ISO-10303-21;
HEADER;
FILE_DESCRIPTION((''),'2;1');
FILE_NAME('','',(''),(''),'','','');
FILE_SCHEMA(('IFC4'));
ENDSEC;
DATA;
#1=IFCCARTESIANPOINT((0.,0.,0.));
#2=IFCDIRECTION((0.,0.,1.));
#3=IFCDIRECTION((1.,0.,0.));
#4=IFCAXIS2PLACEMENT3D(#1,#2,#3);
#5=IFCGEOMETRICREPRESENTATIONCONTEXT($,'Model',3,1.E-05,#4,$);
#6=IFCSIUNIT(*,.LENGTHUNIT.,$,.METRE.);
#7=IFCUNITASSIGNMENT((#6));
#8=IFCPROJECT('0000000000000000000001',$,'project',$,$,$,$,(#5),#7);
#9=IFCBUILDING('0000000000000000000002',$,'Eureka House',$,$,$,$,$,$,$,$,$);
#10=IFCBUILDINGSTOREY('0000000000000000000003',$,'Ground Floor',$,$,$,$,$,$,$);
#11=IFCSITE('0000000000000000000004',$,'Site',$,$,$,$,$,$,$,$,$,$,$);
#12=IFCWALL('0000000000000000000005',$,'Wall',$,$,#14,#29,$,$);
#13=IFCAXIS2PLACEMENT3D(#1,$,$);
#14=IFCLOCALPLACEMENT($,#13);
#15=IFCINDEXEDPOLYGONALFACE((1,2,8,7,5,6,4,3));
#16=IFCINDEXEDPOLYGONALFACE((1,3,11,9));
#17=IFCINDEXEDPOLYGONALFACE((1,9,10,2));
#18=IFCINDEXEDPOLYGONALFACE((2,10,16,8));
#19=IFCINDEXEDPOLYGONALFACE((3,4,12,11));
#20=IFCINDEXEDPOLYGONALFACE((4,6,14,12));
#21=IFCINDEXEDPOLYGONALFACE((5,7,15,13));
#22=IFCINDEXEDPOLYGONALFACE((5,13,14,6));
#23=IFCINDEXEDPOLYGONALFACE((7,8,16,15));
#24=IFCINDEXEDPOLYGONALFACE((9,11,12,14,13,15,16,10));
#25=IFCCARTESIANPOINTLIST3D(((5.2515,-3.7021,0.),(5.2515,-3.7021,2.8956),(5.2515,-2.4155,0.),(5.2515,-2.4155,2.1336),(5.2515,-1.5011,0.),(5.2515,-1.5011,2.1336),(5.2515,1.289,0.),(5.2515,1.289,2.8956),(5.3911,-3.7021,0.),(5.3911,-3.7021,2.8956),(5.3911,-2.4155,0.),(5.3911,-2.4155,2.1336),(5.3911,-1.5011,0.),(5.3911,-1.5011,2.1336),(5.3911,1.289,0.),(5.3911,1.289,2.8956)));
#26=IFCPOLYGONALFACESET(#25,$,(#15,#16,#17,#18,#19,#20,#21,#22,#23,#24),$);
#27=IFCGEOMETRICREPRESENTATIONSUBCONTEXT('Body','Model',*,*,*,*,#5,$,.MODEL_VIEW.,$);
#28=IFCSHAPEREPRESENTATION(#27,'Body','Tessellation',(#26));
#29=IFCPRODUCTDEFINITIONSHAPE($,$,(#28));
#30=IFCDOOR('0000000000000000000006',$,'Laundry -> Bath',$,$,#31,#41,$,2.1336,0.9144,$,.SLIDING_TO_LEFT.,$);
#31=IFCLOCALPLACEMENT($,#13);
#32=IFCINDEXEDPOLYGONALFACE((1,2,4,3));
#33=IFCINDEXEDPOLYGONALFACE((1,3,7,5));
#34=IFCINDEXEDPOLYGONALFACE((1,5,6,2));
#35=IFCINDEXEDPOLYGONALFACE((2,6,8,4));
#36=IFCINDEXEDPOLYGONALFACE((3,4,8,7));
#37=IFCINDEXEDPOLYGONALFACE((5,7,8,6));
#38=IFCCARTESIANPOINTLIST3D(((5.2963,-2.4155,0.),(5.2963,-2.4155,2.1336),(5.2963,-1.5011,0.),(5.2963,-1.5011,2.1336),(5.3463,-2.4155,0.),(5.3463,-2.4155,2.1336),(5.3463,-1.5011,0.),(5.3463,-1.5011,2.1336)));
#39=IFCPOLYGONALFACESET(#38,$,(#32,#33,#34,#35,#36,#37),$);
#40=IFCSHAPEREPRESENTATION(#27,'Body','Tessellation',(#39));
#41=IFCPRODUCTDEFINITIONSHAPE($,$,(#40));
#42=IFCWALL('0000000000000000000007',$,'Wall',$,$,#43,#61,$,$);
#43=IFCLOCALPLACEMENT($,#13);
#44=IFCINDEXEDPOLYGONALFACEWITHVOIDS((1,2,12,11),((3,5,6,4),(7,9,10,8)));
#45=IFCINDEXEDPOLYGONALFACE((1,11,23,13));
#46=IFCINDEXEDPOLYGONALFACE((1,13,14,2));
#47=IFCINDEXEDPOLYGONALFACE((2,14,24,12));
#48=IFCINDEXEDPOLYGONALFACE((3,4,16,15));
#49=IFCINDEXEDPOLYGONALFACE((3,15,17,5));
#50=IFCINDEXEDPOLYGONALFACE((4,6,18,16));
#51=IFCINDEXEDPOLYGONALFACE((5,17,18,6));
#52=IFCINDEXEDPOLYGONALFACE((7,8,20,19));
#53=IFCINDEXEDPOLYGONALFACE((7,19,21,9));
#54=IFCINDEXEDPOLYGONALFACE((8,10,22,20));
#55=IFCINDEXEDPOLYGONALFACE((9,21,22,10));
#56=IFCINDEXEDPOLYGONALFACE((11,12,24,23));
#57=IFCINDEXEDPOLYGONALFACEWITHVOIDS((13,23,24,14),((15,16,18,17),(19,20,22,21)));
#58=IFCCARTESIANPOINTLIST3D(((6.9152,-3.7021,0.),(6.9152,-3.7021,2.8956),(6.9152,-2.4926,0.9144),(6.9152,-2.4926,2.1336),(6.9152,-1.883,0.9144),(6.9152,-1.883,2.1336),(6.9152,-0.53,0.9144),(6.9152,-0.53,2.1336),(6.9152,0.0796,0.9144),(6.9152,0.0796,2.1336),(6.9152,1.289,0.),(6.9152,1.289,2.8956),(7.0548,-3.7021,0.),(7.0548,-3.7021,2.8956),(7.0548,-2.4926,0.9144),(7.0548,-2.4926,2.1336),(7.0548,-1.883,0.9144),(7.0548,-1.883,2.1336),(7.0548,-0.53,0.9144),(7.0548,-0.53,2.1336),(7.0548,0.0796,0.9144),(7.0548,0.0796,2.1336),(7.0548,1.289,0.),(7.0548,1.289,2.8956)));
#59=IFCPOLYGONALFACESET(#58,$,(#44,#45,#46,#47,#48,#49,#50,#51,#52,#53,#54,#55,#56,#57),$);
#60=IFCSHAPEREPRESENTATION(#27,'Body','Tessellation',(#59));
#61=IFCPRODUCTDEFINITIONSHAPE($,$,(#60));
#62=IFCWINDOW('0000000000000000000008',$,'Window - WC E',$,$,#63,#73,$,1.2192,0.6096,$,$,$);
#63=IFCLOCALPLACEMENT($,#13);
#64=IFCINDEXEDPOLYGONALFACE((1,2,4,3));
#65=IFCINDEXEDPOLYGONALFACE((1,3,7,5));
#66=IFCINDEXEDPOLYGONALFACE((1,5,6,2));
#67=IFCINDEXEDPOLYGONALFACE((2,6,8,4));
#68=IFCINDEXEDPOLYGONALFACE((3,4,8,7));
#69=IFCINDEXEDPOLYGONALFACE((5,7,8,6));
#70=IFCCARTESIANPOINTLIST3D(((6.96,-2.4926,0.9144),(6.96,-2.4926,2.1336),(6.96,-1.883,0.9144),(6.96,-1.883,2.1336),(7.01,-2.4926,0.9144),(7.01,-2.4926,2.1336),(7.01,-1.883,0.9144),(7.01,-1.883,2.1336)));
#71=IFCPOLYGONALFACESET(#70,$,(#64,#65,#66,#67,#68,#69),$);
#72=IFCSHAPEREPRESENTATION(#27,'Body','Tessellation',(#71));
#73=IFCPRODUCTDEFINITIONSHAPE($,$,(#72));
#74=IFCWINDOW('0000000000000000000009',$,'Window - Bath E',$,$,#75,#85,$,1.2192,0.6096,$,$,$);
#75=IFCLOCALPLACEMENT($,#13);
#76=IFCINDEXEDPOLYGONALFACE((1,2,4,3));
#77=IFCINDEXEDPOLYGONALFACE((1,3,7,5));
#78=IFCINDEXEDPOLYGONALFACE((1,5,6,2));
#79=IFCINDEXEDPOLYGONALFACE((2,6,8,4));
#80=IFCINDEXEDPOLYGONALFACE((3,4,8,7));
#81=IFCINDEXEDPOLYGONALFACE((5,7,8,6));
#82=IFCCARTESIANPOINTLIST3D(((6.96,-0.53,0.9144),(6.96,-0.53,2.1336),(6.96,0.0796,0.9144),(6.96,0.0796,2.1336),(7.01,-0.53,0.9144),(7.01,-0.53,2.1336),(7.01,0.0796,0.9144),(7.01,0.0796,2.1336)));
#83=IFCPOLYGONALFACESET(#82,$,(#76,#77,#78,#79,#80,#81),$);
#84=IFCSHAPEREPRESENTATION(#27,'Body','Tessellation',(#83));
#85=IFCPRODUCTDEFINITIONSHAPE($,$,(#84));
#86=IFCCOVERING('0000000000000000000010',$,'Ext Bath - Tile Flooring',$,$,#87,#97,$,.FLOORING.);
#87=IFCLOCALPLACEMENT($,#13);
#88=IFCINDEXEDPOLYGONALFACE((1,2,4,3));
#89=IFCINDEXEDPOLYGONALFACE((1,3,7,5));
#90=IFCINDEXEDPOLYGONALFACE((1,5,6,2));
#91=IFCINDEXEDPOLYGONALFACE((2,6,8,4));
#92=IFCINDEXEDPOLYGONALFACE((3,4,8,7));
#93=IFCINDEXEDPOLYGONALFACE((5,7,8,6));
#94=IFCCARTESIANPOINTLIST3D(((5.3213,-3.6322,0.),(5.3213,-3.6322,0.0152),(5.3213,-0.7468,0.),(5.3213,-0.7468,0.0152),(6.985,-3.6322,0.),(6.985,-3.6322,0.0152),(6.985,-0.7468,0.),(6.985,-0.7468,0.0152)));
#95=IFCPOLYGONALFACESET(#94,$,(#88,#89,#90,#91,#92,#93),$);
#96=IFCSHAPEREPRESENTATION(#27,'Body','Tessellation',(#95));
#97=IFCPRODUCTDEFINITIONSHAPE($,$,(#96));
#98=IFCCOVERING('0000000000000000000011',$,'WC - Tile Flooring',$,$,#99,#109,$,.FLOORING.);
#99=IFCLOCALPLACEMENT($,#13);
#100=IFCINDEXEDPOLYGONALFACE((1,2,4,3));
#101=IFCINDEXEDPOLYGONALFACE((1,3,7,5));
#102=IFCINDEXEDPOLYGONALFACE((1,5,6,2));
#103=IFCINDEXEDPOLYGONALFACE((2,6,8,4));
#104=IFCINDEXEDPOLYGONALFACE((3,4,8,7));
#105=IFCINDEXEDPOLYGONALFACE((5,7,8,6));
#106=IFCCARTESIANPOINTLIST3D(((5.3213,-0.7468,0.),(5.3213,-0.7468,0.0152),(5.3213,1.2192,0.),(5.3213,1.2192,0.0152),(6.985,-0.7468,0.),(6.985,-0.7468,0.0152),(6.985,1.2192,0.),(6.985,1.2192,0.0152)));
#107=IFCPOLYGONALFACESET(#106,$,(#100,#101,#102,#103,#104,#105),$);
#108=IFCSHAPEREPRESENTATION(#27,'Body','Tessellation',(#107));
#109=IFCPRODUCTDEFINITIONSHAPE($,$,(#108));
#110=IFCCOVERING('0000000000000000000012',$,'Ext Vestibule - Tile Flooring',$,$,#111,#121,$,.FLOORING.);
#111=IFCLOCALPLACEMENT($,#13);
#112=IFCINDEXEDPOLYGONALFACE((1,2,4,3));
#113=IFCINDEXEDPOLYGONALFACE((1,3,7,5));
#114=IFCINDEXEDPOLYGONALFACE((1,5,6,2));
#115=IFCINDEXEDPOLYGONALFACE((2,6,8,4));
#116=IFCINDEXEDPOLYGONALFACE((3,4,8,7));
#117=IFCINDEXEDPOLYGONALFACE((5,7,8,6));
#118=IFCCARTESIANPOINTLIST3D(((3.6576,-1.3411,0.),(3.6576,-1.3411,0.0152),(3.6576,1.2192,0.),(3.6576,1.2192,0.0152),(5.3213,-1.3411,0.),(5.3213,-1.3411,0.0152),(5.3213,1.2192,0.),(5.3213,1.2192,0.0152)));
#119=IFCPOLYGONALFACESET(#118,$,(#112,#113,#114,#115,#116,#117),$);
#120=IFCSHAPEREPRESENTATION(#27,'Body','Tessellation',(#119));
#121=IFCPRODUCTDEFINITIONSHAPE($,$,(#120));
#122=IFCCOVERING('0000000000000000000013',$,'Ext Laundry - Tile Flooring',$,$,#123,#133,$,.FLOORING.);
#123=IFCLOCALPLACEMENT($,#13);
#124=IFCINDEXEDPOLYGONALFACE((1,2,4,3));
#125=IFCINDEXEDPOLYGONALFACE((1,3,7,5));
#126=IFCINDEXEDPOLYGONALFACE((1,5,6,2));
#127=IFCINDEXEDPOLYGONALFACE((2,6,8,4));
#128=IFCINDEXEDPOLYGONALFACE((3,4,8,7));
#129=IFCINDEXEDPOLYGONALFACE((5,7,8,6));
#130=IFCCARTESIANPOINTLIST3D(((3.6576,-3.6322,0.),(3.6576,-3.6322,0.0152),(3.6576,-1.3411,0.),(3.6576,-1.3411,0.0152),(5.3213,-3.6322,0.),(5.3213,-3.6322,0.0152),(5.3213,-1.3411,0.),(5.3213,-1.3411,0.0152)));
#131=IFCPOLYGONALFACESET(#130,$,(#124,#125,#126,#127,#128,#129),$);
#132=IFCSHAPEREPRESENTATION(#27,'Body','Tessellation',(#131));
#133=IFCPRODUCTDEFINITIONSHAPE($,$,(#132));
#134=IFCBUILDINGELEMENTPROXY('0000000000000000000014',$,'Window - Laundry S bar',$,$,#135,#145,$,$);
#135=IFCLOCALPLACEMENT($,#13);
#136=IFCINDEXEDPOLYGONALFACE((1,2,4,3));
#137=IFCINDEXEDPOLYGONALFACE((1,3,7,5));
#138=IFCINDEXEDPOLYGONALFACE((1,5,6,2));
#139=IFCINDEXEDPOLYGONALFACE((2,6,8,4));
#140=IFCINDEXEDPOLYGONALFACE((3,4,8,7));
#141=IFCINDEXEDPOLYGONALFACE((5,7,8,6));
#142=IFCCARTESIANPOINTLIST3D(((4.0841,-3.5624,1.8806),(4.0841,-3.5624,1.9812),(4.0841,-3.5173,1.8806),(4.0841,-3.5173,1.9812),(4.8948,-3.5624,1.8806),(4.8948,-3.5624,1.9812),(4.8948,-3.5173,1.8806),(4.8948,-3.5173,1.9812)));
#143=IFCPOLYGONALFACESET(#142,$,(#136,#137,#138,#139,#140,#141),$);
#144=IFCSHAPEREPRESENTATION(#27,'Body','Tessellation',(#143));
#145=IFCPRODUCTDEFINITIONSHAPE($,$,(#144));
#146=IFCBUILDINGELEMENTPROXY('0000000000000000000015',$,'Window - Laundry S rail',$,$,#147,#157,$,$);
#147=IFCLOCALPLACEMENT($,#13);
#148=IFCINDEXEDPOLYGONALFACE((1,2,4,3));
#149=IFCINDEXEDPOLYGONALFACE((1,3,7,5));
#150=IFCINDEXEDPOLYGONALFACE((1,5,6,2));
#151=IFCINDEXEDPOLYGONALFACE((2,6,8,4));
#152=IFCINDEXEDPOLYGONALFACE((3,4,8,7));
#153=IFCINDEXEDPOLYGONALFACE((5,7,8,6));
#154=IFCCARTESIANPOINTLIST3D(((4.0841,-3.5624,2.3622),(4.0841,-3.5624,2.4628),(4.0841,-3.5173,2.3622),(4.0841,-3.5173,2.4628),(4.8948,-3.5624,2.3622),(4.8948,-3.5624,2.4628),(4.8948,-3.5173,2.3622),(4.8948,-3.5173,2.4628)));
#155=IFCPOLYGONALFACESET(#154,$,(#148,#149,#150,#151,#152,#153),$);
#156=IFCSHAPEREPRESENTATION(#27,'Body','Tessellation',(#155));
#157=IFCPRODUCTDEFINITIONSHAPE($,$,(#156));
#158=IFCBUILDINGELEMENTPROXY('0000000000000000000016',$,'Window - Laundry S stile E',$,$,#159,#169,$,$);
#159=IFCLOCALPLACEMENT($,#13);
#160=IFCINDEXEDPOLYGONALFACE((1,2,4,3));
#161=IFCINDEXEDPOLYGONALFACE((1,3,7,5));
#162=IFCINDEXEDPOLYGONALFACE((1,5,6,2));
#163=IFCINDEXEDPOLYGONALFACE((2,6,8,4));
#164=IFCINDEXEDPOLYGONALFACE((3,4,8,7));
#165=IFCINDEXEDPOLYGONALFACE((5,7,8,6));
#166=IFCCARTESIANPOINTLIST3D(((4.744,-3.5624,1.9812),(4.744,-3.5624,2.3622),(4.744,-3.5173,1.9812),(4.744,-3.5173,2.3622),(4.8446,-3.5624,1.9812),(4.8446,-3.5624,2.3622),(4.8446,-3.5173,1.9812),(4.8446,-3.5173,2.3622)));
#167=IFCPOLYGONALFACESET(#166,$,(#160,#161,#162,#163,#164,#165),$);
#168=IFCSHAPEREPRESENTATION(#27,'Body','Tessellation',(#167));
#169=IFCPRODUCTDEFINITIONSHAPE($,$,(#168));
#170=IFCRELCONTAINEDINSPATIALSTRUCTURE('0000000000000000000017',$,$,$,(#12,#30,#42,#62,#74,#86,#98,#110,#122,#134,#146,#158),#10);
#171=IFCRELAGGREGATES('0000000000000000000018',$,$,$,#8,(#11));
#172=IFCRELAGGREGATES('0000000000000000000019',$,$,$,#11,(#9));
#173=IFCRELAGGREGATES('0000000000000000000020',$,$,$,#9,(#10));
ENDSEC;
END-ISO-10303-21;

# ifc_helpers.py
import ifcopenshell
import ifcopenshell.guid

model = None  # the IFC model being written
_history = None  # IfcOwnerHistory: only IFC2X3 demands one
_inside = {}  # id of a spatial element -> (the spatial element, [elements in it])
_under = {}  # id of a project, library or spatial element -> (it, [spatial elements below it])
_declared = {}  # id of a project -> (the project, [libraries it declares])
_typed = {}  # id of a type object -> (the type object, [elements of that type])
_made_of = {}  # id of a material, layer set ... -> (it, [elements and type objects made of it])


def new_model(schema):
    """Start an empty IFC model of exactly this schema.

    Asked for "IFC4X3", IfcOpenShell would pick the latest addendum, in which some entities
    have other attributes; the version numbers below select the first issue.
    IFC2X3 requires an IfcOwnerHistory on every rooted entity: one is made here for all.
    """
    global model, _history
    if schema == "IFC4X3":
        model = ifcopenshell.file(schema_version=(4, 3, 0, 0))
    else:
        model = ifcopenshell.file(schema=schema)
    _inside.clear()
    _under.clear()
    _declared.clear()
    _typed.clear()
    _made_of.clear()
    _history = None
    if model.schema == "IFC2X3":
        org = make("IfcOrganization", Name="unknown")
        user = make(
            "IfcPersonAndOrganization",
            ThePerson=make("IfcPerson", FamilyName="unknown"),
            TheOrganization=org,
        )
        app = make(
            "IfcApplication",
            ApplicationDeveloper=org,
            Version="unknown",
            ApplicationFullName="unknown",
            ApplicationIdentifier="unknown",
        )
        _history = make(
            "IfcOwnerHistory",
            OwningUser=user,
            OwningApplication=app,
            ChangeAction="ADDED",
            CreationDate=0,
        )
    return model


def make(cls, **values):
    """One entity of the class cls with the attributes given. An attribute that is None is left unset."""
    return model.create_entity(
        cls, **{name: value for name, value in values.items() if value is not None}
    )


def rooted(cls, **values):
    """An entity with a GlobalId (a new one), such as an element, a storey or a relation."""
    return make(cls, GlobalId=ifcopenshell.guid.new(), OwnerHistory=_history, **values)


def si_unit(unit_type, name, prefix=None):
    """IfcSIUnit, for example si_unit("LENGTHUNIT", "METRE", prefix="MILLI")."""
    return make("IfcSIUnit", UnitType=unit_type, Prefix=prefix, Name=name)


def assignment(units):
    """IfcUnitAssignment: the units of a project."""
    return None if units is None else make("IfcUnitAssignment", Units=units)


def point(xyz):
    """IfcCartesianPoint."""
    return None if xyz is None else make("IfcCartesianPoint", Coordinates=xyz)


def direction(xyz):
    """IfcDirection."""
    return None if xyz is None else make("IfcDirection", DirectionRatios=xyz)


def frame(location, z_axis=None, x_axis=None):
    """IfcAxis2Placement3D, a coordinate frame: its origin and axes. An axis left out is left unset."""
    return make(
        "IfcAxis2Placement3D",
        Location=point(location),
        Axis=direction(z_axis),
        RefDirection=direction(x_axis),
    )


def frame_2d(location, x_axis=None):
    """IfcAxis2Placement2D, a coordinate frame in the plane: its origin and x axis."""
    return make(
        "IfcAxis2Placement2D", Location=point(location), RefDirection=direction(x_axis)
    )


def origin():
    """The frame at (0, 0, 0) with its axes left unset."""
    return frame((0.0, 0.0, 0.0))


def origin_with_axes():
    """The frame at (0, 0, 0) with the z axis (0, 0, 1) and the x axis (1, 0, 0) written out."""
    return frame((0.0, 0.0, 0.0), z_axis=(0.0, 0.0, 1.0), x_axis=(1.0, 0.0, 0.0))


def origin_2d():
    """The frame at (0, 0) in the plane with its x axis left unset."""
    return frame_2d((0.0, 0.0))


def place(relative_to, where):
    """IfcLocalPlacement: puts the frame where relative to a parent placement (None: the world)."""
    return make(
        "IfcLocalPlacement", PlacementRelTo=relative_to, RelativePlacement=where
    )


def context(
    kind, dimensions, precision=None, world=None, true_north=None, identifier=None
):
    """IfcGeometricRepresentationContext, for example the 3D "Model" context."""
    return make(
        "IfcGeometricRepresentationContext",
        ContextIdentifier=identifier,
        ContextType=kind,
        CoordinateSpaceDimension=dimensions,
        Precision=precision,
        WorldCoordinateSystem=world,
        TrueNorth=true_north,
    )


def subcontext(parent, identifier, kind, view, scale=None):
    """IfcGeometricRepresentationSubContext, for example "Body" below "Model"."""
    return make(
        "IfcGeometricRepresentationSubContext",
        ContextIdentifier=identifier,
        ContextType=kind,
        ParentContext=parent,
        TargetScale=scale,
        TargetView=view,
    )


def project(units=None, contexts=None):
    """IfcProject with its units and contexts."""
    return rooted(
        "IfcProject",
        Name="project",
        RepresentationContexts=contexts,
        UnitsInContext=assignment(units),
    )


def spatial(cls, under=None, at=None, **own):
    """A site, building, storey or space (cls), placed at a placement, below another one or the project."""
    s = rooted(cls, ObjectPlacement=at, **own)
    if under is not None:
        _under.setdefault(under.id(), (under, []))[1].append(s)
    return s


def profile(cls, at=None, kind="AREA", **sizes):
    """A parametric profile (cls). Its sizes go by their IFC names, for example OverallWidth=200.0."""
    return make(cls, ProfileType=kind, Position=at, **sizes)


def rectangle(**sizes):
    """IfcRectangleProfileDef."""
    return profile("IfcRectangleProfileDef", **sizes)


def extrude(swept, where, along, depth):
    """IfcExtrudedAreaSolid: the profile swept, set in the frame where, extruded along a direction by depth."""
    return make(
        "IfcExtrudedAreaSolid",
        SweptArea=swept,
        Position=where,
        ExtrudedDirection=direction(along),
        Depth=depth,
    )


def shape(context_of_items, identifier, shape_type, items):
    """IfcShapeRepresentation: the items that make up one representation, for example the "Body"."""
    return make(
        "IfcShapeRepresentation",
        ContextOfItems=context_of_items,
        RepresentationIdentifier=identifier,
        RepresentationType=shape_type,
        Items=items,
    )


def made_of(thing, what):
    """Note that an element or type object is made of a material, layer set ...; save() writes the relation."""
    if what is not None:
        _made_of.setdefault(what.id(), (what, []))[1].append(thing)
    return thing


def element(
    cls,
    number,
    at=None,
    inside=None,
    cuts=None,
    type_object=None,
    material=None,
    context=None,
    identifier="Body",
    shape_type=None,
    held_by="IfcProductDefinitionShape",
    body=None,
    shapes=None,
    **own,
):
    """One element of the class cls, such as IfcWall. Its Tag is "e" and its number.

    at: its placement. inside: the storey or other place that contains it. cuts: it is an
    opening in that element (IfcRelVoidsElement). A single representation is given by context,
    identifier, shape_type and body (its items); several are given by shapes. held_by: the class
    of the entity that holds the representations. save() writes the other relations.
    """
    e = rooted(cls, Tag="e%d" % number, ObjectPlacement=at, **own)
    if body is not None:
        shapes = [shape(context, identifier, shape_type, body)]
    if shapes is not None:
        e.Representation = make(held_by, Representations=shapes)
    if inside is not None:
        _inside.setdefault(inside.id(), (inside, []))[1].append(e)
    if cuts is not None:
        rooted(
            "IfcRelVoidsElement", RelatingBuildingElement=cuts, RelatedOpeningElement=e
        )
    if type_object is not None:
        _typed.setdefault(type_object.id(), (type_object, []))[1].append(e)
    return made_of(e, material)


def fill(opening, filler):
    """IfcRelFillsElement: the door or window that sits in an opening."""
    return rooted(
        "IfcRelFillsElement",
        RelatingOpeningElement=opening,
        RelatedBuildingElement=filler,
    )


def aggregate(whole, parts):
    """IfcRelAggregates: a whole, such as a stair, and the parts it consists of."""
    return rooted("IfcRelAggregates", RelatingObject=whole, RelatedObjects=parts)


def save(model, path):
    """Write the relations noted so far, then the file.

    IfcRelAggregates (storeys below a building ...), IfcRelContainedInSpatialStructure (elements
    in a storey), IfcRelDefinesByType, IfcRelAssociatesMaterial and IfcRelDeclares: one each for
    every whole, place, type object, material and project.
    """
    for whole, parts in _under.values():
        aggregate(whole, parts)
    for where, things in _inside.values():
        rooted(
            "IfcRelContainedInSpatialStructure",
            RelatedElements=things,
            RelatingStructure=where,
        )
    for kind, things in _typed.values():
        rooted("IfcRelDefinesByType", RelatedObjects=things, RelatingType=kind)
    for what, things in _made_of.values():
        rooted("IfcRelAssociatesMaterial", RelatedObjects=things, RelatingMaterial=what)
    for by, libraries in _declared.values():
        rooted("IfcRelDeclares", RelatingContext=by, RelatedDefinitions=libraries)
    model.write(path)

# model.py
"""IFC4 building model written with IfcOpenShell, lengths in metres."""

from ifc_helpers import new_model, si_unit, frame, origin, origin_with_axes, origin_2d, place, context, subcontext, project, spatial, rectangle, extrude, element, fill, save


model = new_model("IFC4")

# Units and contexts
model_context = context("Model", 3, precision=1e-05, world=origin_with_axes())
body_context = subcontext(model_context, "Body", "Model", "MODEL_VIEW")
ifc_project = project(units=[si_unit("LENGTHUNIT", "METRE")], contexts=[model_context])

# Site, building, storey
site = spatial("IfcSite", under=ifc_project, Name="Site")
building = spatial("IfcBuilding", under=site, Name="Eureka House")
storey = spatial("IfcBuildingStorey", under=building, Name="Ground Floor")

# Wall, opening, door
wall_1_placement = place(None, frame((5.3213, -1.2065, 0.0), z_axis=(0.0, 0.0, 1.0), x_axis=(1.0, 0.0, 0.0)))
wall_1 = element("IfcWall", 1, at=wall_1_placement, inside=storey, Name="Wall", context=body_context, shape_type="SweptSolid", body=[
    extrude(rectangle(XDim=0.1397, YDim=4.9911, at=origin_2d()), origin(), (0.0, 0.0, 1.0), 2.8956),
])
opening_1_placement = place(wall_1_placement, frame((0.0, -0.7518, 0.0), z_axis=(0.0, 0.0, 1.0), x_axis=(1.0, 0.0, 0.0)))
opening_1 = element("IfcOpeningElement", 2, at=opening_1_placement, cuts=wall_1, context=body_context, shape_type="SweptSolid", body=[
    extrude(rectangle(XDim=0.2397, YDim=0.9144, at=origin_2d()), origin(), (0.0, 0.0, 1.0), 2.1336),
])
door_1_placement = place(opening_1_placement, origin_with_axes())
door_1 = element("IfcDoor", 3, at=door_1_placement, inside=storey, Name="Laundry -> Bath", OperationType="SLIDING_TO_LEFT", OverallHeight=2.1336, OverallWidth=0.9144, context=body_context, shape_type="SweptSolid", body=[
    extrude(rectangle(XDim=0.05, YDim=0.9144, at=origin_2d()), origin(), (0.0, 0.0, 1.0), 2.1336),
])
fill(opening_1, door_1)

# Wall, openings, windows
wall_2_placement = place(None, frame((6.985, -1.2065, 0.0), z_axis=(0.0, 0.0, 1.0), x_axis=(1.0, 0.0, 0.0)))
wall_2 = element("IfcWall", 4, at=wall_2_placement, inside=storey, Name="Wall", context=body_context, shape_type="SweptSolid", body=[
    extrude(rectangle(XDim=0.1397, YDim=4.9911, at=origin_2d()), origin(), (0.0, 0.0, 1.0), 2.8956),
])
opening_2_placement = place(wall_2_placement, frame((0.0, -0.9813, 0.9144), z_axis=(0.0, 0.0, 1.0), x_axis=(1.0, 0.0, 0.0)))
opening_2 = element("IfcOpeningElement", 5, at=opening_2_placement, cuts=wall_2, context=body_context, shape_type="SweptSolid", body=[
    extrude(rectangle(XDim=0.2397, YDim=0.6096, at=origin_2d()), origin(), (0.0, 0.0, 1.0), 1.2192),
])
opening_3_placement = place(wall_2_placement, frame((0.0, 0.9813, 0.9144), z_axis=(0.0, 0.0, 1.0), x_axis=(1.0, 0.0, 0.0)))
opening_3 = element("IfcOpeningElement", 6, at=opening_3_placement, cuts=wall_2, context=body_context, shape_type="SweptSolid", body=[
    extrude(rectangle(XDim=0.2397, YDim=0.6096, at=origin_2d()), origin(), (0.0, 0.0, 1.0), 1.2192),
])
window_1_placement = place(opening_2_placement, origin_with_axes())
window_1 = element("IfcWindow", 7, at=window_1_placement, inside=storey, Name="Window - WC E", OverallHeight=1.2192, OverallWidth=0.6096, context=body_context, shape_type="SweptSolid", body=[
    extrude(rectangle(XDim=0.05, YDim=0.6096, at=origin_2d()), origin(), (0.0, 0.0, 1.0), 1.2192),
])
fill(opening_2, window_1)
window_2_placement = place(opening_3_placement, frame((0.0, 0.0, 0.0), z_axis=(0.0, 0.0, 1.0), x_axis=(1.0, 0.0, 0.0)))
window_2 = element("IfcWindow", 8, at=window_2_placement, inside=storey, Name="Window - Bath E", OverallHeight=1.2192, OverallWidth=0.6096, context=body_context, shape_type="SweptSolid", body=[
    extrude(rectangle(XDim=0.05, YDim=0.6096, at=origin_2d()), origin(), (0.0, 0.0, 1.0), 1.2192),
])
fill(opening_3, window_2)

# Coverings
covering_1_placement = place(None, frame((6.1532, -2.1895, 0.0), z_axis=(0.0, 0.0, 1.0), x_axis=(1.0, 0.0, 0.0)))
element("IfcCovering", 9, at=covering_1_placement, inside=storey, Name="Ext Bath - Tile Flooring", PredefinedType="FLOORING", context=body_context, shape_type="SweptSolid", body=[
    extrude(rectangle(XDim=1.6637, YDim=2.8855, at=origin_2d()), origin(), (0.0, 0.0, 1.0), 0.0152),
])
covering_2_placement = place(None, frame((6.1532, 0.2362, 0.0), z_axis=(0.0, 0.0, 1.0), x_axis=(1.0, 0.0, 0.0)))
element("IfcCovering", 10, at=covering_2_placement, inside=storey, Name="WC - Tile Flooring", PredefinedType="FLOORING", context=body_context, shape_type="SweptSolid", body=[
    extrude(rectangle(XDim=1.6637, YDim=1.966, at=origin_2d()), origin(), (0.0, 0.0, 1.0), 0.0152),
])
covering_3_placement = place(None, frame((4.4894, -0.061, 0.0), z_axis=(0.0, 0.0, 1.0), x_axis=(1.0, 0.0, 0.0)))
element("IfcCovering", 11, at=covering_3_placement, inside=storey, Name="Ext Vestibule - Tile Flooring", PredefinedType="FLOORING", context=body_context, shape_type="SweptSolid", body=[
    extrude(rectangle(XDim=1.6637, YDim=2.5603, at=origin_2d()), origin(), (0.0, 0.0, 1.0), 0.0152),
])
covering_4_placement = place(None, frame((4.4894, -2.4867, 0.0), z_axis=(0.0, 0.0, 1.0), x_axis=(1.0, 0.0, 0.0)))
element("IfcCovering", 12, at=covering_4_placement, inside=storey, Name="Ext Laundry - Tile Flooring", PredefinedType="FLOORING", context=body_context, shape_type="SweptSolid", body=[
    extrude(rectangle(XDim=1.6637, YDim=2.2911, at=origin_2d()), origin(), (0.0, 0.0, 1.0), 0.0152),
])

# Building element proxies
for number, where, z_axis, x_axis, name in (
    (13, (4.4895, -3.5398, 1.8806), (0.0, 0.0, 1.0), (1.0, 0.0, 0.0), "Window - Laundry S bar"),
    (14, (4.4895, -3.5398, 2.3622), (0.0, 0.0, 1.0), (1.0, 0.0, 0.0), "Window - Laundry S rail"),
):
    element("IfcBuildingElementProxy", number, at=place(None, frame(where, z_axis=z_axis, x_axis=x_axis)), inside=storey, Name=name, context=body_context, shape_type="SweptSolid", body=[
        extrude(rectangle(XDim=0.8108, YDim=0.0451, at=origin_2d()), origin(), (0.0, 0.0, 1.0), 0.1006),
    ])
proxy_placement = place(None, frame((4.7943, -3.5398, 1.9812), z_axis=(0.0, 0.0, 1.0), x_axis=(1.0, 0.0, 0.0)))
element("IfcBuildingElementProxy", 15, at=proxy_placement, inside=storey, Name="Window - Laundry S stile E", context=body_context, shape_type="SweptSolid", body=[
    extrude(rectangle(XDim=0.1006, YDim=0.0451, at=origin_2d()), origin(), (0.0, 0.0, 1.0), 0.381),
])

save(model, "model.ifc")
